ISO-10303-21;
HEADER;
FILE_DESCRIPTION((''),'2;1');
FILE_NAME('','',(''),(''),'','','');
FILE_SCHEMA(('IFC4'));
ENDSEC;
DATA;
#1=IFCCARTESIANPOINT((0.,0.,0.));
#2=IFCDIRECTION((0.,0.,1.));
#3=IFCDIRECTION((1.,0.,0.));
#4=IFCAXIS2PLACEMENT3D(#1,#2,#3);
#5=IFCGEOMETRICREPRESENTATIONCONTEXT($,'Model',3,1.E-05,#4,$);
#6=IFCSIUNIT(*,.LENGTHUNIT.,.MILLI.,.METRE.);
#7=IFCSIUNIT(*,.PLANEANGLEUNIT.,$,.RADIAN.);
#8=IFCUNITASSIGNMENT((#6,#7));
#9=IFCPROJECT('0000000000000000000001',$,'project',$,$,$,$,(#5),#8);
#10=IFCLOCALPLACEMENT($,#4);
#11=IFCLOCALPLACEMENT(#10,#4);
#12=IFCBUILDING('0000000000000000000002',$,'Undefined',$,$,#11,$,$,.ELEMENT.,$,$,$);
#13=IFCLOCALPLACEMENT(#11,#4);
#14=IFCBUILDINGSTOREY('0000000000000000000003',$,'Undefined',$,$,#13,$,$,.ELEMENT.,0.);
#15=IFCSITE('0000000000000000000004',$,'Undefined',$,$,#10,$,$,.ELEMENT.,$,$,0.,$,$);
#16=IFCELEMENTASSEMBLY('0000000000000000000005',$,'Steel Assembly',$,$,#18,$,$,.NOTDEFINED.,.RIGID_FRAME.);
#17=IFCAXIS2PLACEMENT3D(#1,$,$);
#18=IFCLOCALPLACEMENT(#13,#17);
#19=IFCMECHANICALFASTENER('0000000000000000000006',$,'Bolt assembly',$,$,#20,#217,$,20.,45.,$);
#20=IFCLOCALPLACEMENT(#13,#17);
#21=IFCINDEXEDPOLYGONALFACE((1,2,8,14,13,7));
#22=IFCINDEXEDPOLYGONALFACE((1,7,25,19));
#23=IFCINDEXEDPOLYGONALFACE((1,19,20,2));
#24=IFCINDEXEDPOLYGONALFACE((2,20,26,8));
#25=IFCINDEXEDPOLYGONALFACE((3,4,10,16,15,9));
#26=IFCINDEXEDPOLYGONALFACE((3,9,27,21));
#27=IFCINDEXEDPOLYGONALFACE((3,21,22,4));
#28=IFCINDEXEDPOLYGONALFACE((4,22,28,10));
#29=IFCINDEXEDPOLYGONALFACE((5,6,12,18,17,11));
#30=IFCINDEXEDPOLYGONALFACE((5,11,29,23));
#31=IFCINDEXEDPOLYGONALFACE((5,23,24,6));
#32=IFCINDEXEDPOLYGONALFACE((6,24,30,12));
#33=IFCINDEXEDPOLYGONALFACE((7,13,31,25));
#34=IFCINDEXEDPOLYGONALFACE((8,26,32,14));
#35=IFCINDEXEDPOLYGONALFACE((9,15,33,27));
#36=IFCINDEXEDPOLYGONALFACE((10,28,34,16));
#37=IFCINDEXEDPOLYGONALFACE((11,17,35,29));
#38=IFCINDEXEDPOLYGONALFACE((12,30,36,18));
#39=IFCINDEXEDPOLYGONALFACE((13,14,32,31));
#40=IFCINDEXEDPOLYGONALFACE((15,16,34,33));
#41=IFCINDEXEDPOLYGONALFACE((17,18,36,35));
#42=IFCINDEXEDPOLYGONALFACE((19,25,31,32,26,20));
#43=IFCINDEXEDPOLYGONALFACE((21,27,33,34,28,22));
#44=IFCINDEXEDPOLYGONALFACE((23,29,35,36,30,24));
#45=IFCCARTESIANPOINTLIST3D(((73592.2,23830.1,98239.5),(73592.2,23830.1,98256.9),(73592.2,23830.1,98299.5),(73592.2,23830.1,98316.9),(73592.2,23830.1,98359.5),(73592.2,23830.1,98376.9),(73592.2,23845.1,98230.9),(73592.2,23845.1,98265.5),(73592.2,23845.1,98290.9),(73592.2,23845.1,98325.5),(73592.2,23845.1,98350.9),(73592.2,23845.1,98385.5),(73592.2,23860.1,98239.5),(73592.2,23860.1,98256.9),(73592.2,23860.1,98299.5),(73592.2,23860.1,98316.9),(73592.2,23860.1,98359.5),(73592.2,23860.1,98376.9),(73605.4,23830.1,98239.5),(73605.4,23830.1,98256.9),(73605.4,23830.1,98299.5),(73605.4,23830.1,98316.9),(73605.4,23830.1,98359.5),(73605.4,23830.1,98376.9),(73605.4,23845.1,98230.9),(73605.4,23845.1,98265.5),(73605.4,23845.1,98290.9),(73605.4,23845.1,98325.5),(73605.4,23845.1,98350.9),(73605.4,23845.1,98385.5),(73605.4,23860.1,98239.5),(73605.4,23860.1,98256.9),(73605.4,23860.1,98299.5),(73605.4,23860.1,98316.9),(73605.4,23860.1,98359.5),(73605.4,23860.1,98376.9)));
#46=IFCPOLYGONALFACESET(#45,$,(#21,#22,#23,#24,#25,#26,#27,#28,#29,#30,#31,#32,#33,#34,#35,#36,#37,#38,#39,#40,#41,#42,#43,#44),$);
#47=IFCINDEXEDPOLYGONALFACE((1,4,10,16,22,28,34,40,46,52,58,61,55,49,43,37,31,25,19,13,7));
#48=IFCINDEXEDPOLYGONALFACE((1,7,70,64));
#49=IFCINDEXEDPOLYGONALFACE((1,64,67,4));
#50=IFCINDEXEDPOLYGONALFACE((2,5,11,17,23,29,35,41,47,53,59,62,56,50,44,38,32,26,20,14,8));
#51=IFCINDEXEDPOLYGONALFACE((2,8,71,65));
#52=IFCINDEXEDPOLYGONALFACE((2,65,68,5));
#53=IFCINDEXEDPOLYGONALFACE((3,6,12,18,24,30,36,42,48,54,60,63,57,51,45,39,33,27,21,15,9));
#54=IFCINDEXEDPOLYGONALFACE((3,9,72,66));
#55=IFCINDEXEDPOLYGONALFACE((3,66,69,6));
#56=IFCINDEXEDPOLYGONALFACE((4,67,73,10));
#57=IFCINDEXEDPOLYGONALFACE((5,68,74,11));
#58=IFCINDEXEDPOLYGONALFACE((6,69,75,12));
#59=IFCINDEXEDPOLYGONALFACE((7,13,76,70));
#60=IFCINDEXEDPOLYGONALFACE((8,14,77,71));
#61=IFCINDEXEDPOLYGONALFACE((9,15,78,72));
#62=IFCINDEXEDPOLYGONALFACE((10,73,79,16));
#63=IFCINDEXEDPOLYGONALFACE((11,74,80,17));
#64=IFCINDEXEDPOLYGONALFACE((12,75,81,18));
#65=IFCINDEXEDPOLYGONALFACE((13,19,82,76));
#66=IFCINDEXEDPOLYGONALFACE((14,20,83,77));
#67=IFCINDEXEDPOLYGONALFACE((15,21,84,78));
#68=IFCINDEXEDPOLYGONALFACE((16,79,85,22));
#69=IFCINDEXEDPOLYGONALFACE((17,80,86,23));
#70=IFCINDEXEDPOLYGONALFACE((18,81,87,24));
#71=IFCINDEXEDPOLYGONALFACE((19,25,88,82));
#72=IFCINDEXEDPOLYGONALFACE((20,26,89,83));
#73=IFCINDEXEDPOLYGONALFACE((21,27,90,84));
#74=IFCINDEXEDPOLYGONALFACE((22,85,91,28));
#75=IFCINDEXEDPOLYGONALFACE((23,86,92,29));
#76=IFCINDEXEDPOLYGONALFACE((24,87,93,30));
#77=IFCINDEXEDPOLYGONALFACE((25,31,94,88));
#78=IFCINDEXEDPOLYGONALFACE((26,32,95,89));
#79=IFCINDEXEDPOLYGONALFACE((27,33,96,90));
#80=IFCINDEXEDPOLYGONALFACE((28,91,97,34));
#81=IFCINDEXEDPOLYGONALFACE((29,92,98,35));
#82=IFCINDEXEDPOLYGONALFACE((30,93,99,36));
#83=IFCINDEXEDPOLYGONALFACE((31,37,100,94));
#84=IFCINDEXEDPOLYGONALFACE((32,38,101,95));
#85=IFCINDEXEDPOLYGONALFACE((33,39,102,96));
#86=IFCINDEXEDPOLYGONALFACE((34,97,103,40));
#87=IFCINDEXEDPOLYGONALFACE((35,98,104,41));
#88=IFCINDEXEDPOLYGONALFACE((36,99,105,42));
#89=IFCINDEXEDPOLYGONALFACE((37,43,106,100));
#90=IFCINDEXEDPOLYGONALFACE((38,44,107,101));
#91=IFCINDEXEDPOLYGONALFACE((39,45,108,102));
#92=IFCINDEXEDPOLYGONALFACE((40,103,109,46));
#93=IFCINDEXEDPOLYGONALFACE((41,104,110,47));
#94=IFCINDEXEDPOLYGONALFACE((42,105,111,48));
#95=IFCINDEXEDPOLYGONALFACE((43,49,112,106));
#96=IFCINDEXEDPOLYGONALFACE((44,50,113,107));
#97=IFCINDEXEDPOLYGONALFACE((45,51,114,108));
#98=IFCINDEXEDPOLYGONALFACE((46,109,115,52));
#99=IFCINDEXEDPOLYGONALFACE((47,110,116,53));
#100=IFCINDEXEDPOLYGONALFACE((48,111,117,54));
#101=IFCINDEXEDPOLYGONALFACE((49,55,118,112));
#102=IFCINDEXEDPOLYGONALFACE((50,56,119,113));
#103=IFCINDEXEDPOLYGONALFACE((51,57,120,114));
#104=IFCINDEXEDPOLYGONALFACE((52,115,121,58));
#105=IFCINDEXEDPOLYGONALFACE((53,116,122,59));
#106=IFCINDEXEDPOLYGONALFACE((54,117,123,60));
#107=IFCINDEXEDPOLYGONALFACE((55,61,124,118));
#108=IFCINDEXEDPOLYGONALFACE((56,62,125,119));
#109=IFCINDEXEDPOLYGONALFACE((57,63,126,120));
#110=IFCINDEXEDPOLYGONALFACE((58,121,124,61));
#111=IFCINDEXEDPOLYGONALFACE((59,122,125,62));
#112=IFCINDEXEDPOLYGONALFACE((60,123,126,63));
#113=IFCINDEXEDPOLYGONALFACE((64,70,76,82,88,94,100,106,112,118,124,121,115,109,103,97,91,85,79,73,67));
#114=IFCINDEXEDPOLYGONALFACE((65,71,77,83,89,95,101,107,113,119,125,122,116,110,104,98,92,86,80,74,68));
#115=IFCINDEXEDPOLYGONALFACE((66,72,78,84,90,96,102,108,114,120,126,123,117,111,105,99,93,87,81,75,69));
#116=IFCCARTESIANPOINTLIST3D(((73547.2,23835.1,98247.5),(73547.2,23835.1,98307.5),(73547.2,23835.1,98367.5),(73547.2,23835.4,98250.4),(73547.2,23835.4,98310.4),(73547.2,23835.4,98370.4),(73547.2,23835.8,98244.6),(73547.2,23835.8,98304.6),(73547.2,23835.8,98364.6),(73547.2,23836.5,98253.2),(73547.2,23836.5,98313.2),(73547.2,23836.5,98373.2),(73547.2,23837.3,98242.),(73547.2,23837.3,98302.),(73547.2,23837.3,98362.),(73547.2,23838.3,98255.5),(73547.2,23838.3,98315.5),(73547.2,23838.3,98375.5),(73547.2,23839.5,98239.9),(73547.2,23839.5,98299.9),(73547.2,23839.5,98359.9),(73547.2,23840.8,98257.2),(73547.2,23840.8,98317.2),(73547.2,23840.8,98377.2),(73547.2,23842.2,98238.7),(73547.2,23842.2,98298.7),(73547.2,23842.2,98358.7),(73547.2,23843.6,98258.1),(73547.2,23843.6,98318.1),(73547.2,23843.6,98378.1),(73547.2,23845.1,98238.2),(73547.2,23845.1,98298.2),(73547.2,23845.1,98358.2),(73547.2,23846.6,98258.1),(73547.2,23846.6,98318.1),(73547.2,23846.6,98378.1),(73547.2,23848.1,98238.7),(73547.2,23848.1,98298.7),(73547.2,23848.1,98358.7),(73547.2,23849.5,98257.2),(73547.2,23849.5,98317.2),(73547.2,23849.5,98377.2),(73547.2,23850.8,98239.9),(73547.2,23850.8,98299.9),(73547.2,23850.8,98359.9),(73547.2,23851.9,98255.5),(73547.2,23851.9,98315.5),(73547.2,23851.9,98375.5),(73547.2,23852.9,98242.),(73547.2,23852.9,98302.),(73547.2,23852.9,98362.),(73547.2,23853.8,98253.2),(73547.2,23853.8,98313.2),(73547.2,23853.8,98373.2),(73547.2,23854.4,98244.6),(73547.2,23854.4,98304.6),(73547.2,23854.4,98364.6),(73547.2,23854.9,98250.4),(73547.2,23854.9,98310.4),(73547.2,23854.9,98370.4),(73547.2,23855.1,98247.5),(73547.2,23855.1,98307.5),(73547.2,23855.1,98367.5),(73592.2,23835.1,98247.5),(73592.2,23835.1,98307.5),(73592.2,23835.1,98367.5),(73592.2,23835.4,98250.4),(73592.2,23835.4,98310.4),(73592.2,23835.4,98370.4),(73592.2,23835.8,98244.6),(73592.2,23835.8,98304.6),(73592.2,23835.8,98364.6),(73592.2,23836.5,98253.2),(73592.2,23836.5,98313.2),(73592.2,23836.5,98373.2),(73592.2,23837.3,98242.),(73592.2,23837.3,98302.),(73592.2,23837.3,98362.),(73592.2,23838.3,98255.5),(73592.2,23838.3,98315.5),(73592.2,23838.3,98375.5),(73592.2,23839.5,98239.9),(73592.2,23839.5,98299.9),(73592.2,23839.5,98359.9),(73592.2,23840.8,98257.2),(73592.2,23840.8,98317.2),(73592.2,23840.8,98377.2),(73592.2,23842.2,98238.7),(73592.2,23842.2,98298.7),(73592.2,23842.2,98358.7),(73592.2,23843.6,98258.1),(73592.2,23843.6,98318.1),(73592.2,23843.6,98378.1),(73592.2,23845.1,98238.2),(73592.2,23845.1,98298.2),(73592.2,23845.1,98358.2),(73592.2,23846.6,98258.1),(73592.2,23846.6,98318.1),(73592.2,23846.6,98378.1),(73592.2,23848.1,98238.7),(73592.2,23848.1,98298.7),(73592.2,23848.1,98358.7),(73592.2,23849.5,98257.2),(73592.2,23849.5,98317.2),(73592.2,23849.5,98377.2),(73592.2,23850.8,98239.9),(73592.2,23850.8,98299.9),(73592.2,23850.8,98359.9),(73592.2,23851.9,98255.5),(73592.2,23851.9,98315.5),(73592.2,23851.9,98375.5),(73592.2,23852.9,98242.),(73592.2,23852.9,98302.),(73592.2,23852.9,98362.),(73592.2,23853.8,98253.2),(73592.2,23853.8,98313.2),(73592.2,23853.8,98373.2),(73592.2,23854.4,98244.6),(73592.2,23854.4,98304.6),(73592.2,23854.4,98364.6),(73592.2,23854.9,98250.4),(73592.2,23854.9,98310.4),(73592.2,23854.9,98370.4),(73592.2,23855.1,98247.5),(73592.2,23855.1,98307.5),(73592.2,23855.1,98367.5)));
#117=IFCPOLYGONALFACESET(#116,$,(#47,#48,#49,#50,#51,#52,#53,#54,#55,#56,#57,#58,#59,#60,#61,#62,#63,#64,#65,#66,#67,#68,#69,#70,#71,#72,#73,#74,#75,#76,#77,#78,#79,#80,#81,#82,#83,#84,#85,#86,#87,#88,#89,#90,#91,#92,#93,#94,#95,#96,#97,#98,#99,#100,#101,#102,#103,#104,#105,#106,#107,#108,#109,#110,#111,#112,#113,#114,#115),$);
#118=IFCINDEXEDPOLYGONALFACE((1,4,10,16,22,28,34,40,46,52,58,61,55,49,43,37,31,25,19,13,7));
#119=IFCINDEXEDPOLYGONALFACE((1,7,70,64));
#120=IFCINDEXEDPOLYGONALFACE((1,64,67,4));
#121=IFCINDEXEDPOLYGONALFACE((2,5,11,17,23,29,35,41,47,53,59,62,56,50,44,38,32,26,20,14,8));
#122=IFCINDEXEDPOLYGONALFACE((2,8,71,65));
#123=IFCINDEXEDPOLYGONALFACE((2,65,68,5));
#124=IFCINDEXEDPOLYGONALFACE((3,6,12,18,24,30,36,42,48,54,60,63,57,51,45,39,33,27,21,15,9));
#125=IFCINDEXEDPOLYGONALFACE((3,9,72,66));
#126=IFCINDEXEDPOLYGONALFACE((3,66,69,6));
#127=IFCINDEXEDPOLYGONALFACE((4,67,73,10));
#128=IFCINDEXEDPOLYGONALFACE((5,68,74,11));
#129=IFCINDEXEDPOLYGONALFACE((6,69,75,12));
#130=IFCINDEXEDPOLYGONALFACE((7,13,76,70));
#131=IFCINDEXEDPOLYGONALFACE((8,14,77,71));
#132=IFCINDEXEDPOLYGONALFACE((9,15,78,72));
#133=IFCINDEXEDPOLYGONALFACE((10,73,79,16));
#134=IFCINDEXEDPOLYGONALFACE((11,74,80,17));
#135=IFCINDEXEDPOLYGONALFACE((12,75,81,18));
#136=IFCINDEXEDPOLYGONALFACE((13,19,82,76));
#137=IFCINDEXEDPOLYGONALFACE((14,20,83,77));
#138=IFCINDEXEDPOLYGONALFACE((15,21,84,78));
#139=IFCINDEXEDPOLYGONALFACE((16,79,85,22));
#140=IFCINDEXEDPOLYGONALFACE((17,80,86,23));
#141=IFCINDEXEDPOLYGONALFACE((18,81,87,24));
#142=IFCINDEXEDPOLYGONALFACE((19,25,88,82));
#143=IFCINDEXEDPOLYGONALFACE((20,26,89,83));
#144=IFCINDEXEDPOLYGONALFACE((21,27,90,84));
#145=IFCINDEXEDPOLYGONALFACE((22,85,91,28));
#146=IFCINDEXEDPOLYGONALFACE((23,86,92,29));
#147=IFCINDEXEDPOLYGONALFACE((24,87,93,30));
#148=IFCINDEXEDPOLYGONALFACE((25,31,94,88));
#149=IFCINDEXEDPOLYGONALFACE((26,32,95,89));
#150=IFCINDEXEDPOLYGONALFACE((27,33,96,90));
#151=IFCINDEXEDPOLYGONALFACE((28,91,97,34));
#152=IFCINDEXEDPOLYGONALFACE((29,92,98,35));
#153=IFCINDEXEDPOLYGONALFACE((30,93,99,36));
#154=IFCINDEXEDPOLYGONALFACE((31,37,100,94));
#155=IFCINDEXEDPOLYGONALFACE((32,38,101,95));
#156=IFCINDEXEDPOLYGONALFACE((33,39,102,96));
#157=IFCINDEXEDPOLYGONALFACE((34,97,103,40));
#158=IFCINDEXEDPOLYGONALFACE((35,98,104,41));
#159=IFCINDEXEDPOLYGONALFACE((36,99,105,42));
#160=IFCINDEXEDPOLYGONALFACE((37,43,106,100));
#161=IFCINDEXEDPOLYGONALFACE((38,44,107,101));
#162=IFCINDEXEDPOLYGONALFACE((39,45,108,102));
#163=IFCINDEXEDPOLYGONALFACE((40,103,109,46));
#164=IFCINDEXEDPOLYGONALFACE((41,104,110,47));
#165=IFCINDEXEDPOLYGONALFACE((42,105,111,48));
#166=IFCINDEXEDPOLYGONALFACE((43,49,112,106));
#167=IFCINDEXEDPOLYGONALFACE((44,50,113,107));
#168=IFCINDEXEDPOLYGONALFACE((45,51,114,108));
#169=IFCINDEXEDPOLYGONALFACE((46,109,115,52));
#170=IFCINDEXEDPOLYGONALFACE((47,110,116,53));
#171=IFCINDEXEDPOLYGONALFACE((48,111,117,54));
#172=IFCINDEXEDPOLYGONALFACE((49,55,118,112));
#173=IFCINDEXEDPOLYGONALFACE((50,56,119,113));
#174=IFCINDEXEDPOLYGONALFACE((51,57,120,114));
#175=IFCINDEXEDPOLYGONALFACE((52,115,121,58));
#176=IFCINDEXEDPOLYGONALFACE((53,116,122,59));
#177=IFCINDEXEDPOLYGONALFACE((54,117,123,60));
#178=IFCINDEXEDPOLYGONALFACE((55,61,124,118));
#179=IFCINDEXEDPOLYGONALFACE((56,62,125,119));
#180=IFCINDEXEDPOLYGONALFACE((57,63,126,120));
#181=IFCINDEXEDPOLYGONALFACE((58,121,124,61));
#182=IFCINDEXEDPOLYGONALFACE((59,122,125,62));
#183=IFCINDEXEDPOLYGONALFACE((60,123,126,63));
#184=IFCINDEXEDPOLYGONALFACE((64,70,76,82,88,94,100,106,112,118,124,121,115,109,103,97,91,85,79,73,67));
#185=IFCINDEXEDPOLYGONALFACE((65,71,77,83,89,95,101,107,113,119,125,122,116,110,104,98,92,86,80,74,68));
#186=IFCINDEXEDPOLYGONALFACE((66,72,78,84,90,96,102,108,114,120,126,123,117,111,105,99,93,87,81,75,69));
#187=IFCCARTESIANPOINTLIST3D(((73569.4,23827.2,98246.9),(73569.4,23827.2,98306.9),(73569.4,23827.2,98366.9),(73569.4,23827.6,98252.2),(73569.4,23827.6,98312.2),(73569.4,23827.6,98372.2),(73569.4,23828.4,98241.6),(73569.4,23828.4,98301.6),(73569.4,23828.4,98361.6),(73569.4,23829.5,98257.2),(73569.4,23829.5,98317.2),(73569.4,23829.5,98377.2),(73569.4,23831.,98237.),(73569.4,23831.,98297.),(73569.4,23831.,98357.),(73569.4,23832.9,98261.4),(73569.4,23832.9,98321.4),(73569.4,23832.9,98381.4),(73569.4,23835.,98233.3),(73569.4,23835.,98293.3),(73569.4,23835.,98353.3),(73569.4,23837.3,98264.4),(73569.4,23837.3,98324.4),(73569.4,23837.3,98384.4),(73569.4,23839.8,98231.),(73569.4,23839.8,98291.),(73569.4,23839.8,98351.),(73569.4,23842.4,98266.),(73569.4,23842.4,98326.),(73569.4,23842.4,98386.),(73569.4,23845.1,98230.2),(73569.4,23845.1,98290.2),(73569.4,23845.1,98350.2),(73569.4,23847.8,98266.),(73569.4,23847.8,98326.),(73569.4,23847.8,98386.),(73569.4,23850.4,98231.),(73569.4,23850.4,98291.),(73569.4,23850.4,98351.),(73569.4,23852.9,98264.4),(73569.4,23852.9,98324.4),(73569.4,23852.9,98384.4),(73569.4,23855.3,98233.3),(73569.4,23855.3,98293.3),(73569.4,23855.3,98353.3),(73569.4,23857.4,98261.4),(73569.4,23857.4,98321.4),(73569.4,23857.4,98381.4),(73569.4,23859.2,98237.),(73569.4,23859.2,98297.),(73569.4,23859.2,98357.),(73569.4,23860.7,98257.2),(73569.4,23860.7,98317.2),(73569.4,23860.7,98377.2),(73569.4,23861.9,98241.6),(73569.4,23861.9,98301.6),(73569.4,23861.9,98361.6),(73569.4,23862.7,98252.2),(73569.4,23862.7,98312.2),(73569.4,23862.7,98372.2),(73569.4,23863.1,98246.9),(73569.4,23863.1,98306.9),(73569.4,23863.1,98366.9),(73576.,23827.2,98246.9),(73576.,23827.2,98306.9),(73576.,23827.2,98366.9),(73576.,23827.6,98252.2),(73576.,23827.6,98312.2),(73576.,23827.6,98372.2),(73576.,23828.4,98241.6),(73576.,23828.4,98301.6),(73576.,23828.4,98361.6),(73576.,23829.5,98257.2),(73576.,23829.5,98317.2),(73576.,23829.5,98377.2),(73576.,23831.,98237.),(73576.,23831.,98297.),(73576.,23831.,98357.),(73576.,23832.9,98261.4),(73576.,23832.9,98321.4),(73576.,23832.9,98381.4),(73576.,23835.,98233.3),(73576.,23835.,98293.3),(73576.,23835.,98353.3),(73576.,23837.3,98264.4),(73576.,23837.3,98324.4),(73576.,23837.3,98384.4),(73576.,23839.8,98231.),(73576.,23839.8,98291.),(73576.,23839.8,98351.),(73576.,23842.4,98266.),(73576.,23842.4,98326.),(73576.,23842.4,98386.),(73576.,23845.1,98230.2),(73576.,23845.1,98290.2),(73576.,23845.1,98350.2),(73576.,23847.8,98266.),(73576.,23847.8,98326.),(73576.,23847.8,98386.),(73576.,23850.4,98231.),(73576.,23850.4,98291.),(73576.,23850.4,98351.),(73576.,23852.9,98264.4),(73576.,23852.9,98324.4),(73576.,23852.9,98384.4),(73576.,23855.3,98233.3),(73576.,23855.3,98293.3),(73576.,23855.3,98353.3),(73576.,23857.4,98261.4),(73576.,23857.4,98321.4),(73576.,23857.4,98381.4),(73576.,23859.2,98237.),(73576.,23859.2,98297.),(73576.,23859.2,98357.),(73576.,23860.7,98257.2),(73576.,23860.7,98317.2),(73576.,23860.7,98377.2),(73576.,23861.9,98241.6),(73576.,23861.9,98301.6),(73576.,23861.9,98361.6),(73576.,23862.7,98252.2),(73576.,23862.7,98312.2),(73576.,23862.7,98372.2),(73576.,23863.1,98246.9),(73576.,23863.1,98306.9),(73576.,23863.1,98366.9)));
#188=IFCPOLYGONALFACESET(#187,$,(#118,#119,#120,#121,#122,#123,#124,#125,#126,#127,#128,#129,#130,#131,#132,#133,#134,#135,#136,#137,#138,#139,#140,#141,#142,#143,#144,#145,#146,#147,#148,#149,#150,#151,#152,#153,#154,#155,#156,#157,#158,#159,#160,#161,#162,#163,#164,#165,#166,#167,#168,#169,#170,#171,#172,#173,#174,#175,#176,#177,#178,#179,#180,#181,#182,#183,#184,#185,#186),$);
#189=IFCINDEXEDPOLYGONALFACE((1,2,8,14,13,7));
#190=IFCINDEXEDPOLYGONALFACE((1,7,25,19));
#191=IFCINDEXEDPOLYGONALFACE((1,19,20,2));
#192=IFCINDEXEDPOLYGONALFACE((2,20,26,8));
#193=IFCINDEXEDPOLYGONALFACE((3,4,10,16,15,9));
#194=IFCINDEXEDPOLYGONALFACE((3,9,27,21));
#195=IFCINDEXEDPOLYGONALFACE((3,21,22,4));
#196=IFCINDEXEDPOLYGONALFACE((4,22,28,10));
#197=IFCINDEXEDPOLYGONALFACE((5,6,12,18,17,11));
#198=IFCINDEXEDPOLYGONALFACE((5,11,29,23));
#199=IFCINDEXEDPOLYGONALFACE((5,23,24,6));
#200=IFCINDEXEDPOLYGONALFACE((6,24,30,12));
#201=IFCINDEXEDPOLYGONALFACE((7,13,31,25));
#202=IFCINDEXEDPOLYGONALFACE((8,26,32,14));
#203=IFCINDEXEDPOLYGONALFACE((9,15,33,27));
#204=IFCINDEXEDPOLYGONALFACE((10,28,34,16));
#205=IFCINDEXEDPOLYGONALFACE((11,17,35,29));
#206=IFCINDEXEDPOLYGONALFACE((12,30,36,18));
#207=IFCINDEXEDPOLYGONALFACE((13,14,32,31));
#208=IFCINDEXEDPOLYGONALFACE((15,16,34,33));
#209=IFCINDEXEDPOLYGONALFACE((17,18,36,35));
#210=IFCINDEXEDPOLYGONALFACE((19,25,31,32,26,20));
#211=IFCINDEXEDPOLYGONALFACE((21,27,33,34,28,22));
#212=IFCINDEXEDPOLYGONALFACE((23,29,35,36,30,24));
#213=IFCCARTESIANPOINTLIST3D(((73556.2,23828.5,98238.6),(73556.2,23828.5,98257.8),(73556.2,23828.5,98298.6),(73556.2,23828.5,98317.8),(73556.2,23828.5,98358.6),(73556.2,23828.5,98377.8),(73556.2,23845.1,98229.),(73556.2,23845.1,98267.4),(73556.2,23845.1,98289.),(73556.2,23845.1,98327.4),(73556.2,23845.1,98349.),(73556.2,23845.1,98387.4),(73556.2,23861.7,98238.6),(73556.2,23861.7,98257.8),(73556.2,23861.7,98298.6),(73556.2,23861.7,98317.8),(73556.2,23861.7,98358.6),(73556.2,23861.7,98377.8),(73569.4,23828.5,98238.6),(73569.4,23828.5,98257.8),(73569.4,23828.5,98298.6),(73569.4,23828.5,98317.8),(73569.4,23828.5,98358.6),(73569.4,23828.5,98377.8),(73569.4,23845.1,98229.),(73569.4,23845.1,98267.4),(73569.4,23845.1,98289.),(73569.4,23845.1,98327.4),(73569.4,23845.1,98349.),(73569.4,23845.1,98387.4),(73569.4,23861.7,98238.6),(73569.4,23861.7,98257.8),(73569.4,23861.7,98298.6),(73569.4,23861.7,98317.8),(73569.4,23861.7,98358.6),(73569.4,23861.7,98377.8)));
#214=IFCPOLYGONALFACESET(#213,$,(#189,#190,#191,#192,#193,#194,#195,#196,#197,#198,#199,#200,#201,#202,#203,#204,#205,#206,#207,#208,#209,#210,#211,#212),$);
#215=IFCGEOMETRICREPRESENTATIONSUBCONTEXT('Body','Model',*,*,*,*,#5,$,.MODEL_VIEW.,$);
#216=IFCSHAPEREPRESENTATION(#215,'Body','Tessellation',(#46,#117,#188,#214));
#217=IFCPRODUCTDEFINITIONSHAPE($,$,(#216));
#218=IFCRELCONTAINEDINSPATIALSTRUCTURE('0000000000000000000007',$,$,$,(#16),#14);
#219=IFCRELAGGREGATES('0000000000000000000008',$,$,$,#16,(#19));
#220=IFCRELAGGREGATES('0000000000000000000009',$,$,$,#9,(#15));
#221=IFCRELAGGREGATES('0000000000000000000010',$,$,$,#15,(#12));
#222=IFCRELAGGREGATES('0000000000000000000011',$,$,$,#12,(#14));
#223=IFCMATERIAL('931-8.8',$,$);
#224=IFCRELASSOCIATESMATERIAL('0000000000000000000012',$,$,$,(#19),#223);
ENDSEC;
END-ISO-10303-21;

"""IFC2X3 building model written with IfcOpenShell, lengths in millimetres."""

from ifc_helpers import new_model, si_unit, frame, origin_with_axes, origin_2d_with_axis, place, context, subcontext, project, spatial, polyline, circle, outline, extrude, source, transform, mapped, material, element, aggregate, save


model = new_model("IFC2X3")

# Units and contexts
model_context = context("Model", 3, precision=1e-05, world=origin_with_axes())
body_context = subcontext(model_context, "Body", "Model", "MODEL_VIEW")
ifc_project = project(units=[si_unit("LENGTHUNIT", "METRE", prefix="MILLI"), si_unit("PLANEANGLEUNIT", "RADIAN")], contexts=[model_context])

# Site, building, storey
site_placement = place(None, origin_with_axes())
site = spatial("IfcSite", under=ifc_project, at=site_placement, Name="Undefined", CompositionType="ELEMENT", RefElevation=0.0)
building_placement = place(site_placement, origin_with_axes())
building = spatial("IfcBuilding", under=site, at=building_placement, Name="Undefined", CompositionType="ELEMENT")
storey_placement = place(building_placement, origin_with_axes())
storey = spatial("IfcBuildingStorey", under=building, at=storey_placement, Name="Undefined", CompositionType="ELEMENT", Elevation=0.0)

# Shared definitions
ifc_material_1 = material(Name="931-8.8")

# Element assembly, mechanical fastener
assembly_1_placement = place(storey_placement, origin_with_axes())
assembly_1 = element("IfcElementAssembly", 1, at=assembly_1_placement, inside=storey, Name="Steel Assembly", AssemblyPlace="NOTDEFINED", PredefinedType="RIGID_FRAME")
shared_shape_1 = source(origin_with_axes(), body_context, "Body", "SweptSolid", [
    extrude(outline(polyline([(17.3, 0.0), (8.7, 15.0), (-8.7, 15.0), (-17.3, 0.0), (-8.7, -15.0), (8.7, -15.0), (17.3, 0.0)])), frame((0.0, -19.4, 0.0), z_axis=(0.0, 1.0, 0.0), x_axis=(1.0, 0.0, 0.0)), (0.0, 0.0, 1.0), 13.2),
    extrude(circle(Radius=10.0, at=origin_2d_with_axis()), frame((0.0, -6.2, 0.0), z_axis=(0.0, 1.0, 0.0), x_axis=(1.0, 0.0, 0.0)), (0.0, 0.0, 1.0), 45.0),
    extrude(circle(Radius=18.0, at=origin_2d_with_axis()), frame((0.0, 10.0, 0.0), z_axis=(0.0, 1.0, 0.0), x_axis=(1.0, 0.0, 0.0)), (0.0, 0.0, 1.0), 6.6),
    extrude(outline(polyline([(19.2, 0.0), (9.6, 16.6), (-9.6, 16.6), (-19.2, 0.0), (-9.6, -16.6), (9.6, -16.6), (19.2, 0.0)])), frame((0.0, 16.6, 0.0), z_axis=(0.0, 1.0, 0.0), x_axis=(1.0, 0.0, 0.0)), (0.0, 0.0, 1.0), 13.2),
])
mechanical_fastener_1_placement = place(assembly_1_placement, frame((73586.0, 23845.1, 98368.2), z_axis=(0.0, 1.0, 0.0), x_axis=(0.0, 0.0, -1.0)))
mechanical_fastener_1 = element("IfcMechanicalFastener", 2, at=mechanical_fastener_1_placement, material=ifc_material_1, Name="Bolt assembly", NominalDiameter=20.0, NominalLength=45.0, context=body_context, shape_type="MappedRepresentation", body=[
    mapped(shared_shape_1, transform((0.0, 0.0, 0.0))),
    mapped(shared_shape_1, transform((60.0, 0.0, 0.0))),
    mapped(shared_shape_1, transform((120.0, 0.0, 0.0))),
])

aggregate(assembly_1, [mechanical_fastener_1])

save(model, "model.ifc")
